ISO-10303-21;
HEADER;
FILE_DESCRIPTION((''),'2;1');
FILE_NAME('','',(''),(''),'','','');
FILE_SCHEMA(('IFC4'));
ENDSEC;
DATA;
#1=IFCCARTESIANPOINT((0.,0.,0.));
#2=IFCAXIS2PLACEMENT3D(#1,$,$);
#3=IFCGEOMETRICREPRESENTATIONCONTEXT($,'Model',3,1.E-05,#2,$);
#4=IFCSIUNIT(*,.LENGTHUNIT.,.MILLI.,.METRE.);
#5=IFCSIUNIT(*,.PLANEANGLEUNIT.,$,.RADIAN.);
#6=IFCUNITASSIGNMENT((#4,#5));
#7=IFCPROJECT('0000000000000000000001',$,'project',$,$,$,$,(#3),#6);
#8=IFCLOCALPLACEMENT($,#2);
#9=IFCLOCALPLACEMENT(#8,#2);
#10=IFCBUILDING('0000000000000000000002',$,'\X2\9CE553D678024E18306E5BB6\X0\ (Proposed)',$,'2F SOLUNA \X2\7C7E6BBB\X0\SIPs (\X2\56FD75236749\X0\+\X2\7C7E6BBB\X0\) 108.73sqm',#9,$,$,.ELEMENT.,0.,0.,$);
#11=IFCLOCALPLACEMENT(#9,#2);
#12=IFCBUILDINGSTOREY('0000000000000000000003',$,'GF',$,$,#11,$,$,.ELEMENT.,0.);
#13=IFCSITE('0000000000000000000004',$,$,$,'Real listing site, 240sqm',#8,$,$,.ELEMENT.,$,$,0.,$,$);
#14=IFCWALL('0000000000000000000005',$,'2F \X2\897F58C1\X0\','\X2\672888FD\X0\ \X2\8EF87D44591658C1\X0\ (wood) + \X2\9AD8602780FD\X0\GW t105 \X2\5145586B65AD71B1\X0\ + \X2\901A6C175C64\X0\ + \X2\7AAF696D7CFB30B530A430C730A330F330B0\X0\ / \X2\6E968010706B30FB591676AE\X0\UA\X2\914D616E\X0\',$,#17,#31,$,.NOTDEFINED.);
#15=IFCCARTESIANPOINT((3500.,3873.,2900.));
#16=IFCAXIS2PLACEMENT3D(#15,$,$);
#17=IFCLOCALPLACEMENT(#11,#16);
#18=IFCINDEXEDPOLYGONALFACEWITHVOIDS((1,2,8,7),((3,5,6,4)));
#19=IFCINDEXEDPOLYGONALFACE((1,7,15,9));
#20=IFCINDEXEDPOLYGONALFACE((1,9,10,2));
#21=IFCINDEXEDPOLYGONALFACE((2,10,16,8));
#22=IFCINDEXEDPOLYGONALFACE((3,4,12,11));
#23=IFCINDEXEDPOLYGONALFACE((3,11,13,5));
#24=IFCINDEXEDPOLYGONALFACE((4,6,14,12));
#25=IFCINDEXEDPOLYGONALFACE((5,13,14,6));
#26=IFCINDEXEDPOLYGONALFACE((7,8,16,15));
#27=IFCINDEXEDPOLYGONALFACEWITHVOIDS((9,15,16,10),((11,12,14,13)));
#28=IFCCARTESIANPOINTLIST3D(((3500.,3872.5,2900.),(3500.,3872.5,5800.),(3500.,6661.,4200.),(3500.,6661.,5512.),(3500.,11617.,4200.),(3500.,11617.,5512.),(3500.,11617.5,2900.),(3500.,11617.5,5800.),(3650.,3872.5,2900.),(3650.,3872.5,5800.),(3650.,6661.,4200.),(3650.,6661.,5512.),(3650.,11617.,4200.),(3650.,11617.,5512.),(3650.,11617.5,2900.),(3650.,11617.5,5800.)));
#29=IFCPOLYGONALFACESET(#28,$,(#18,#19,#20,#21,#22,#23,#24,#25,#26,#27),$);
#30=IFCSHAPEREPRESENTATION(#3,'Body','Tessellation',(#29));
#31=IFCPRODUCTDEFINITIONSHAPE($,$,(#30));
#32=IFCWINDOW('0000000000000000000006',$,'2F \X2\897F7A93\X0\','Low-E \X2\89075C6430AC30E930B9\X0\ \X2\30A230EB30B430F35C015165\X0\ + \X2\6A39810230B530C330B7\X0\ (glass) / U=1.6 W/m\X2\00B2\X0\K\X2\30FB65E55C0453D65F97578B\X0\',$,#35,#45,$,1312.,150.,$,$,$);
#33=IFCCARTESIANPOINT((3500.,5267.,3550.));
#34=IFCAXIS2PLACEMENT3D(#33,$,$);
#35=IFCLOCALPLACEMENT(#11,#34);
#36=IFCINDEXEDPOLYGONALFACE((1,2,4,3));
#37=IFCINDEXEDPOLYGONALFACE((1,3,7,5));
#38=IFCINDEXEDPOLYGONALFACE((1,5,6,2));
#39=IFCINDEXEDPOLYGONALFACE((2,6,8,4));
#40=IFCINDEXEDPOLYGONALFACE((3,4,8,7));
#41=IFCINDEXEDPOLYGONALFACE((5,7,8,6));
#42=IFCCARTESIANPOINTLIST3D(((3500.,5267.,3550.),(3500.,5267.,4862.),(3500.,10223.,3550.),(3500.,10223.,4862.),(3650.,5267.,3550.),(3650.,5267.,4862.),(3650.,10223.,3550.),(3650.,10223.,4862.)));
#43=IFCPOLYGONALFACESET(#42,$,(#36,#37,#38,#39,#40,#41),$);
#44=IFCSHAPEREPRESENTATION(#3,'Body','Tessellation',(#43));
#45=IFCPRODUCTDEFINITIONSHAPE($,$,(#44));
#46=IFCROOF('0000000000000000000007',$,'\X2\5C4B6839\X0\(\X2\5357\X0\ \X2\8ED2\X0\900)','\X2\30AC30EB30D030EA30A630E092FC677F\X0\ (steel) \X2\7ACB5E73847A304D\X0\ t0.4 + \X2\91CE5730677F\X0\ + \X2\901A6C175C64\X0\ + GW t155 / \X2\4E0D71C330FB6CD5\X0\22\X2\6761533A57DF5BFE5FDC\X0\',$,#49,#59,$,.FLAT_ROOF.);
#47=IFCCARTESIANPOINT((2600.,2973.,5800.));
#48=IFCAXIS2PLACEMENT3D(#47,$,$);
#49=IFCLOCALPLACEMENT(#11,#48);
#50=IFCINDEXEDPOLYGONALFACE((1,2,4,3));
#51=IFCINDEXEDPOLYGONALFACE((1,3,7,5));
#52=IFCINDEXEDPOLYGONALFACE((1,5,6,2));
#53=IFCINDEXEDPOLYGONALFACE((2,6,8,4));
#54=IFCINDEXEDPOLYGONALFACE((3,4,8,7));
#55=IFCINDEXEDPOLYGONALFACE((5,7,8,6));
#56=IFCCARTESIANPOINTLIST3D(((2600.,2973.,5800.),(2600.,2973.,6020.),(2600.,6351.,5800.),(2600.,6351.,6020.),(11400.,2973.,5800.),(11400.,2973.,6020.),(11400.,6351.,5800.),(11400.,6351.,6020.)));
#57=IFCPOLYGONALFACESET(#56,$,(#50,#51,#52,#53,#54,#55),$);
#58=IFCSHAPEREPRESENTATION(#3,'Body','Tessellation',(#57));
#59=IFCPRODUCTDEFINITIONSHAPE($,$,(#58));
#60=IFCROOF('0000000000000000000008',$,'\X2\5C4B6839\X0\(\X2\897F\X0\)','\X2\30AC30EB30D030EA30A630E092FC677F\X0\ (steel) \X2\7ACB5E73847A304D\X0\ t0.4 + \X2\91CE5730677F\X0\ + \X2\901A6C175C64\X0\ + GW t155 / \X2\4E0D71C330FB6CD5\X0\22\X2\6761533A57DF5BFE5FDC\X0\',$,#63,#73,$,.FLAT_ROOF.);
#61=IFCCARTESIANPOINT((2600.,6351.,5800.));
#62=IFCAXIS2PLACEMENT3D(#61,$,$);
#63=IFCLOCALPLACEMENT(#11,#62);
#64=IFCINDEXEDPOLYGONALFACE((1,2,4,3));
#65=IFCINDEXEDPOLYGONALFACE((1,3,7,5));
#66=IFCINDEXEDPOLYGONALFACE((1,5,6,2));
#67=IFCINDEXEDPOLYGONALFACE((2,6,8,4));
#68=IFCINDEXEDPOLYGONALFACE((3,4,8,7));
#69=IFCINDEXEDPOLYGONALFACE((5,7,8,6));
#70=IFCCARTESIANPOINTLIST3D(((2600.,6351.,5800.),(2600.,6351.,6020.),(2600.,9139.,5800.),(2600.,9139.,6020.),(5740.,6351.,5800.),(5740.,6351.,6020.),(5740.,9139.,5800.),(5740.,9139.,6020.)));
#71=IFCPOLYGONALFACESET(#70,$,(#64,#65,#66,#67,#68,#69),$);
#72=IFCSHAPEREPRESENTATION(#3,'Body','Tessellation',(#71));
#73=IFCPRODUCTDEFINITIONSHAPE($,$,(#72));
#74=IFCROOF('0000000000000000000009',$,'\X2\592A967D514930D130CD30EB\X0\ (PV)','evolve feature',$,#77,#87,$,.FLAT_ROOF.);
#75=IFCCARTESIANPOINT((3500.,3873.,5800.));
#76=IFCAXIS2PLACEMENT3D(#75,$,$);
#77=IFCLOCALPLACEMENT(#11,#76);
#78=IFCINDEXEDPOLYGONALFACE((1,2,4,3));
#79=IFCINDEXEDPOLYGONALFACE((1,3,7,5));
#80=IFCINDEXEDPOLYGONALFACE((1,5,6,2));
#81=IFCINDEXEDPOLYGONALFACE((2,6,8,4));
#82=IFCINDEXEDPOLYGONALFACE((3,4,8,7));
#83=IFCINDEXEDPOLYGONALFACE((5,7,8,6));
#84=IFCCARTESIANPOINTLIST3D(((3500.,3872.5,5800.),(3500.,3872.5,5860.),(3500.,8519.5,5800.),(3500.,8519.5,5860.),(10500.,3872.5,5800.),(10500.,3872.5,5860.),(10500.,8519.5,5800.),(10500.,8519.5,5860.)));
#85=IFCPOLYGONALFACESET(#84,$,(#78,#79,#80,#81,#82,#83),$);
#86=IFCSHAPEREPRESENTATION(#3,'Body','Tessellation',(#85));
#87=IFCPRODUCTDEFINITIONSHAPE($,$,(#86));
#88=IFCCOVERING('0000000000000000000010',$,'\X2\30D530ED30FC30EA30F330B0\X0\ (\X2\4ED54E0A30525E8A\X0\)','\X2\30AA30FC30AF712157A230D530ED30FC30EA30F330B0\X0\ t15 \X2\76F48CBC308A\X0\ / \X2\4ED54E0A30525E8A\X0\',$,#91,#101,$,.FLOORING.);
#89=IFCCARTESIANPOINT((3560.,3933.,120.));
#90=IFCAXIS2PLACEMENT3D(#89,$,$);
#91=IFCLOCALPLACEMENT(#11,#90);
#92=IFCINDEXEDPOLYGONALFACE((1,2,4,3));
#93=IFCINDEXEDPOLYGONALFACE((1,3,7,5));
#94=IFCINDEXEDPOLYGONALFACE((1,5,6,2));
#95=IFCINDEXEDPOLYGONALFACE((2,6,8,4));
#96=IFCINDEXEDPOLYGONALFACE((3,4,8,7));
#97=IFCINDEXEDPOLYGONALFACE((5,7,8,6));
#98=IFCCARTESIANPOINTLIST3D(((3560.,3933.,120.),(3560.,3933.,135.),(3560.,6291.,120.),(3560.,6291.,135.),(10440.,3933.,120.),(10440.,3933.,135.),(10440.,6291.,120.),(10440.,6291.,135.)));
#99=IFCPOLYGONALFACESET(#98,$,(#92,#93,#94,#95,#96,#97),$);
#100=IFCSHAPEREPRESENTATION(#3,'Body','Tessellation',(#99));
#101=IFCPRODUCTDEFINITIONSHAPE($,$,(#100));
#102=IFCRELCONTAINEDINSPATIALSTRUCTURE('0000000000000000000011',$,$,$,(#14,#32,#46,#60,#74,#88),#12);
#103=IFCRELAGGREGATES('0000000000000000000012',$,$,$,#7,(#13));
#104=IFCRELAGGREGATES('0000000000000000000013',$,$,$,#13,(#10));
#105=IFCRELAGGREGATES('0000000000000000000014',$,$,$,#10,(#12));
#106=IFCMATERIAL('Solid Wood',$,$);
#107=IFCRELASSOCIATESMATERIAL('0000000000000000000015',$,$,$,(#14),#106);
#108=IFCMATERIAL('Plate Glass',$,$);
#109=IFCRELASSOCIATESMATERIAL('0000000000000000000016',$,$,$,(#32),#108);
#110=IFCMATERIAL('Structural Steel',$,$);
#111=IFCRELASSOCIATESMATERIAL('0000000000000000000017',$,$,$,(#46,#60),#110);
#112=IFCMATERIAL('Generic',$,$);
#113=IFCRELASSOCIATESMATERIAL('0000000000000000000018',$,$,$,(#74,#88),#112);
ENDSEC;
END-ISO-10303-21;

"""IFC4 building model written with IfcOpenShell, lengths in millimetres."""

from ifc_helpers import new_model, si_unit, frame, frame_2d, origin, place, context, project, spatial, rectangle, extrude, material, element, fill, save


model = new_model("IFC4")

# Units and contexts
model_context = context("Model", 3, precision=1e-05, world=origin())
ifc_project = project(units=[si_unit("LENGTHUNIT", "METRE", prefix="MILLI"), si_unit("PLANEANGLEUNIT", "RADIAN")], contexts=[model_context])

# Site, building, storey
site_placement = place(None, origin())
site = spatial("IfcSite", under=ifc_project, at=site_placement, ObjectType="Real listing site, 240sqm", CompositionType="ELEMENT", RefElevation=0.0)
building_placement = place(site_placement, origin())
building = spatial("IfcBuilding", under=site, at=building_placement, Name="鳥取砂丘の家 (Proposed)", ObjectType="2F SOLUNA 籾殻SIPs (国産杉+籾殻) 108.73sqm", CompositionType="ELEMENT", ElevationOfRefHeight=0.0, ElevationOfTerrain=0.0)
storey_placement = place(building_placement, origin())
storey = spatial("IfcBuildingStorey", under=building, at=storey_placement, Name="GF", CompositionType="ELEMENT", Elevation=0.0)

# Shared definitions
ifc_material_1 = material(Name="Solid Wood")
ifc_material_2 = material(Name="Generic")

# Shared definitions
ifc_material_3 = material(Name="Plate Glass")

# Wall, opening, window
wall_1_placement = place(storey_placement, frame((3500.0, 3873.0, 2900.0)))
wall_1 = element("IfcWall", 1, at=wall_1_placement, inside=storey, material=ifc_material_1, Name="2F 西壁", Description="木製 軸組外壁 (wood) + 高性能GW t105 充填断熱 + 通気層 + 窯業系サイディング / 準耐火・外皮UA配慮", PredefinedType="NOTDEFINED", context=model_context, shape_type="SweptSolid", body=[
    extrude(rectangle(XDim=150.0, YDim=7745.0, at=frame_2d((75.0, 3872.0))), frame((3500.0, 3873.0, 2900.0)), (0.0, 0.0, 1.0), 2900.0),
])
opening_1_placement = place(storey_placement, frame((3500.0, 5267.0, 3550.0)))
opening_1 = element("IfcOpeningElement", 2, at=opening_1_placement, cuts=wall_1, PredefinedType="NOTDEFINED", context=model_context, shape_type="SweptSolid", body=[
    extrude(rectangle(XDim=150.0, YDim=4956.0, at=frame_2d((75.0, 2478.0))), frame((3500.0, 5267.0, 3550.0)), (0.0, 0.0, 1.0), 1312.0),
])
window_1_placement = place(storey_placement, frame((3500.0, 5267.0, 3550.0)))
window_1 = element("IfcWindow", 3, at=window_1_placement, inside=storey, material=ifc_material_3, Name="2F 西窓", Description="Low-E 複層ガラス アルゴン封入 + 樹脂サッシ (glass) / U=1.6 W/m²K・日射取得型", OverallHeight=1312.0, OverallWidth=150.0, context=model_context, shape_type="SweptSolid", body=[
    extrude(rectangle(XDim=150.0, YDim=4956.0, at=frame_2d((75.0, 2478.0))), frame((3500.0, 5267.0, 3550.0)), (0.0, 0.0, 1.0), 1312.0),
])
fill(opening_1, window_1)

# Roofs
ifc_material_4 = material(Name="Structural Steel")
roof_1_placement = place(storey_placement, frame((2600.0, 2973.0, 5800.0)))
element("IfcRoof", 4, at=roof_1_placement, inside=storey, material=ifc_material_4, Name="屋根(南 軒900)", Description="ガルバリウム鋼板 (steel) 立平葺き t0.4 + 野地板 + 通気層 + GW t155 / 不燃・法22条区域対応", PredefinedType="FLAT_ROOF", context=model_context, shape_type="SweptSolid", body=[
    extrude(rectangle(XDim=8800.0, YDim=3378.0, at=frame_2d((4400.0, 1689.0))), frame((2600.0, 2973.0, 5800.0)), (0.0, 0.0, 1.0), 220.0),
])
roof_2_placement = place(storey_placement, frame((2600.0, 6351.0, 5800.0)))
element("IfcRoof", 5, at=roof_2_placement, inside=storey, material=ifc_material_4, Name="屋根(西)", Description="ガルバリウム鋼板 (steel) 立平葺き t0.4 + 野地板 + 通気層 + GW t155 / 不燃・法22条区域対応", PredefinedType="FLAT_ROOF", context=model_context, shape_type="SweptSolid", body=[
    extrude(rectangle(XDim=3140.0, YDim=2788.0, at=frame_2d((1570.0, 1394.0))), frame((2600.0, 6351.0, 5800.0)), (0.0, 0.0, 1.0), 220.0),
])
roof_3_placement = place(storey_placement, frame((3500.0, 3873.0, 5800.0)))
element("IfcRoof", 6, at=roof_3_placement, inside=storey, material=ifc_material_2, Name="太陽光パネル (PV)", Description="evolve feature", PredefinedType="FLAT_ROOF", context=model_context, shape_type="SweptSolid", body=[
    extrude(rectangle(XDim=7000.0, YDim=4647.0, at=frame_2d((3500.0, 2323.0))), frame((3500.0, 3873.0, 5800.0)), (0.0, 0.0, 1.0), 60.0),
])

# Covering
covering_placement = place(storey_placement, frame((3560.0, 3933.0, 120.0)))
element("IfcCovering", 7, at=covering_placement, inside=storey, material=ifc_material_2, Name="フローリング (仕上げ床)", Description="オーク無垢フローリング t15 直貼り / 仕上げ床", PredefinedType="FLOORING", context=model_context, shape_type="SweptSolid", body=[
    extrude(rectangle(XDim=6880.0, YDim=2358.0, at=frame_2d((3440.0, 1179.0))), frame((3560.0, 3933.0, 120.0)), (0.0, 0.0, 1.0), 15.0),
])

save(model, "model.ifc")
